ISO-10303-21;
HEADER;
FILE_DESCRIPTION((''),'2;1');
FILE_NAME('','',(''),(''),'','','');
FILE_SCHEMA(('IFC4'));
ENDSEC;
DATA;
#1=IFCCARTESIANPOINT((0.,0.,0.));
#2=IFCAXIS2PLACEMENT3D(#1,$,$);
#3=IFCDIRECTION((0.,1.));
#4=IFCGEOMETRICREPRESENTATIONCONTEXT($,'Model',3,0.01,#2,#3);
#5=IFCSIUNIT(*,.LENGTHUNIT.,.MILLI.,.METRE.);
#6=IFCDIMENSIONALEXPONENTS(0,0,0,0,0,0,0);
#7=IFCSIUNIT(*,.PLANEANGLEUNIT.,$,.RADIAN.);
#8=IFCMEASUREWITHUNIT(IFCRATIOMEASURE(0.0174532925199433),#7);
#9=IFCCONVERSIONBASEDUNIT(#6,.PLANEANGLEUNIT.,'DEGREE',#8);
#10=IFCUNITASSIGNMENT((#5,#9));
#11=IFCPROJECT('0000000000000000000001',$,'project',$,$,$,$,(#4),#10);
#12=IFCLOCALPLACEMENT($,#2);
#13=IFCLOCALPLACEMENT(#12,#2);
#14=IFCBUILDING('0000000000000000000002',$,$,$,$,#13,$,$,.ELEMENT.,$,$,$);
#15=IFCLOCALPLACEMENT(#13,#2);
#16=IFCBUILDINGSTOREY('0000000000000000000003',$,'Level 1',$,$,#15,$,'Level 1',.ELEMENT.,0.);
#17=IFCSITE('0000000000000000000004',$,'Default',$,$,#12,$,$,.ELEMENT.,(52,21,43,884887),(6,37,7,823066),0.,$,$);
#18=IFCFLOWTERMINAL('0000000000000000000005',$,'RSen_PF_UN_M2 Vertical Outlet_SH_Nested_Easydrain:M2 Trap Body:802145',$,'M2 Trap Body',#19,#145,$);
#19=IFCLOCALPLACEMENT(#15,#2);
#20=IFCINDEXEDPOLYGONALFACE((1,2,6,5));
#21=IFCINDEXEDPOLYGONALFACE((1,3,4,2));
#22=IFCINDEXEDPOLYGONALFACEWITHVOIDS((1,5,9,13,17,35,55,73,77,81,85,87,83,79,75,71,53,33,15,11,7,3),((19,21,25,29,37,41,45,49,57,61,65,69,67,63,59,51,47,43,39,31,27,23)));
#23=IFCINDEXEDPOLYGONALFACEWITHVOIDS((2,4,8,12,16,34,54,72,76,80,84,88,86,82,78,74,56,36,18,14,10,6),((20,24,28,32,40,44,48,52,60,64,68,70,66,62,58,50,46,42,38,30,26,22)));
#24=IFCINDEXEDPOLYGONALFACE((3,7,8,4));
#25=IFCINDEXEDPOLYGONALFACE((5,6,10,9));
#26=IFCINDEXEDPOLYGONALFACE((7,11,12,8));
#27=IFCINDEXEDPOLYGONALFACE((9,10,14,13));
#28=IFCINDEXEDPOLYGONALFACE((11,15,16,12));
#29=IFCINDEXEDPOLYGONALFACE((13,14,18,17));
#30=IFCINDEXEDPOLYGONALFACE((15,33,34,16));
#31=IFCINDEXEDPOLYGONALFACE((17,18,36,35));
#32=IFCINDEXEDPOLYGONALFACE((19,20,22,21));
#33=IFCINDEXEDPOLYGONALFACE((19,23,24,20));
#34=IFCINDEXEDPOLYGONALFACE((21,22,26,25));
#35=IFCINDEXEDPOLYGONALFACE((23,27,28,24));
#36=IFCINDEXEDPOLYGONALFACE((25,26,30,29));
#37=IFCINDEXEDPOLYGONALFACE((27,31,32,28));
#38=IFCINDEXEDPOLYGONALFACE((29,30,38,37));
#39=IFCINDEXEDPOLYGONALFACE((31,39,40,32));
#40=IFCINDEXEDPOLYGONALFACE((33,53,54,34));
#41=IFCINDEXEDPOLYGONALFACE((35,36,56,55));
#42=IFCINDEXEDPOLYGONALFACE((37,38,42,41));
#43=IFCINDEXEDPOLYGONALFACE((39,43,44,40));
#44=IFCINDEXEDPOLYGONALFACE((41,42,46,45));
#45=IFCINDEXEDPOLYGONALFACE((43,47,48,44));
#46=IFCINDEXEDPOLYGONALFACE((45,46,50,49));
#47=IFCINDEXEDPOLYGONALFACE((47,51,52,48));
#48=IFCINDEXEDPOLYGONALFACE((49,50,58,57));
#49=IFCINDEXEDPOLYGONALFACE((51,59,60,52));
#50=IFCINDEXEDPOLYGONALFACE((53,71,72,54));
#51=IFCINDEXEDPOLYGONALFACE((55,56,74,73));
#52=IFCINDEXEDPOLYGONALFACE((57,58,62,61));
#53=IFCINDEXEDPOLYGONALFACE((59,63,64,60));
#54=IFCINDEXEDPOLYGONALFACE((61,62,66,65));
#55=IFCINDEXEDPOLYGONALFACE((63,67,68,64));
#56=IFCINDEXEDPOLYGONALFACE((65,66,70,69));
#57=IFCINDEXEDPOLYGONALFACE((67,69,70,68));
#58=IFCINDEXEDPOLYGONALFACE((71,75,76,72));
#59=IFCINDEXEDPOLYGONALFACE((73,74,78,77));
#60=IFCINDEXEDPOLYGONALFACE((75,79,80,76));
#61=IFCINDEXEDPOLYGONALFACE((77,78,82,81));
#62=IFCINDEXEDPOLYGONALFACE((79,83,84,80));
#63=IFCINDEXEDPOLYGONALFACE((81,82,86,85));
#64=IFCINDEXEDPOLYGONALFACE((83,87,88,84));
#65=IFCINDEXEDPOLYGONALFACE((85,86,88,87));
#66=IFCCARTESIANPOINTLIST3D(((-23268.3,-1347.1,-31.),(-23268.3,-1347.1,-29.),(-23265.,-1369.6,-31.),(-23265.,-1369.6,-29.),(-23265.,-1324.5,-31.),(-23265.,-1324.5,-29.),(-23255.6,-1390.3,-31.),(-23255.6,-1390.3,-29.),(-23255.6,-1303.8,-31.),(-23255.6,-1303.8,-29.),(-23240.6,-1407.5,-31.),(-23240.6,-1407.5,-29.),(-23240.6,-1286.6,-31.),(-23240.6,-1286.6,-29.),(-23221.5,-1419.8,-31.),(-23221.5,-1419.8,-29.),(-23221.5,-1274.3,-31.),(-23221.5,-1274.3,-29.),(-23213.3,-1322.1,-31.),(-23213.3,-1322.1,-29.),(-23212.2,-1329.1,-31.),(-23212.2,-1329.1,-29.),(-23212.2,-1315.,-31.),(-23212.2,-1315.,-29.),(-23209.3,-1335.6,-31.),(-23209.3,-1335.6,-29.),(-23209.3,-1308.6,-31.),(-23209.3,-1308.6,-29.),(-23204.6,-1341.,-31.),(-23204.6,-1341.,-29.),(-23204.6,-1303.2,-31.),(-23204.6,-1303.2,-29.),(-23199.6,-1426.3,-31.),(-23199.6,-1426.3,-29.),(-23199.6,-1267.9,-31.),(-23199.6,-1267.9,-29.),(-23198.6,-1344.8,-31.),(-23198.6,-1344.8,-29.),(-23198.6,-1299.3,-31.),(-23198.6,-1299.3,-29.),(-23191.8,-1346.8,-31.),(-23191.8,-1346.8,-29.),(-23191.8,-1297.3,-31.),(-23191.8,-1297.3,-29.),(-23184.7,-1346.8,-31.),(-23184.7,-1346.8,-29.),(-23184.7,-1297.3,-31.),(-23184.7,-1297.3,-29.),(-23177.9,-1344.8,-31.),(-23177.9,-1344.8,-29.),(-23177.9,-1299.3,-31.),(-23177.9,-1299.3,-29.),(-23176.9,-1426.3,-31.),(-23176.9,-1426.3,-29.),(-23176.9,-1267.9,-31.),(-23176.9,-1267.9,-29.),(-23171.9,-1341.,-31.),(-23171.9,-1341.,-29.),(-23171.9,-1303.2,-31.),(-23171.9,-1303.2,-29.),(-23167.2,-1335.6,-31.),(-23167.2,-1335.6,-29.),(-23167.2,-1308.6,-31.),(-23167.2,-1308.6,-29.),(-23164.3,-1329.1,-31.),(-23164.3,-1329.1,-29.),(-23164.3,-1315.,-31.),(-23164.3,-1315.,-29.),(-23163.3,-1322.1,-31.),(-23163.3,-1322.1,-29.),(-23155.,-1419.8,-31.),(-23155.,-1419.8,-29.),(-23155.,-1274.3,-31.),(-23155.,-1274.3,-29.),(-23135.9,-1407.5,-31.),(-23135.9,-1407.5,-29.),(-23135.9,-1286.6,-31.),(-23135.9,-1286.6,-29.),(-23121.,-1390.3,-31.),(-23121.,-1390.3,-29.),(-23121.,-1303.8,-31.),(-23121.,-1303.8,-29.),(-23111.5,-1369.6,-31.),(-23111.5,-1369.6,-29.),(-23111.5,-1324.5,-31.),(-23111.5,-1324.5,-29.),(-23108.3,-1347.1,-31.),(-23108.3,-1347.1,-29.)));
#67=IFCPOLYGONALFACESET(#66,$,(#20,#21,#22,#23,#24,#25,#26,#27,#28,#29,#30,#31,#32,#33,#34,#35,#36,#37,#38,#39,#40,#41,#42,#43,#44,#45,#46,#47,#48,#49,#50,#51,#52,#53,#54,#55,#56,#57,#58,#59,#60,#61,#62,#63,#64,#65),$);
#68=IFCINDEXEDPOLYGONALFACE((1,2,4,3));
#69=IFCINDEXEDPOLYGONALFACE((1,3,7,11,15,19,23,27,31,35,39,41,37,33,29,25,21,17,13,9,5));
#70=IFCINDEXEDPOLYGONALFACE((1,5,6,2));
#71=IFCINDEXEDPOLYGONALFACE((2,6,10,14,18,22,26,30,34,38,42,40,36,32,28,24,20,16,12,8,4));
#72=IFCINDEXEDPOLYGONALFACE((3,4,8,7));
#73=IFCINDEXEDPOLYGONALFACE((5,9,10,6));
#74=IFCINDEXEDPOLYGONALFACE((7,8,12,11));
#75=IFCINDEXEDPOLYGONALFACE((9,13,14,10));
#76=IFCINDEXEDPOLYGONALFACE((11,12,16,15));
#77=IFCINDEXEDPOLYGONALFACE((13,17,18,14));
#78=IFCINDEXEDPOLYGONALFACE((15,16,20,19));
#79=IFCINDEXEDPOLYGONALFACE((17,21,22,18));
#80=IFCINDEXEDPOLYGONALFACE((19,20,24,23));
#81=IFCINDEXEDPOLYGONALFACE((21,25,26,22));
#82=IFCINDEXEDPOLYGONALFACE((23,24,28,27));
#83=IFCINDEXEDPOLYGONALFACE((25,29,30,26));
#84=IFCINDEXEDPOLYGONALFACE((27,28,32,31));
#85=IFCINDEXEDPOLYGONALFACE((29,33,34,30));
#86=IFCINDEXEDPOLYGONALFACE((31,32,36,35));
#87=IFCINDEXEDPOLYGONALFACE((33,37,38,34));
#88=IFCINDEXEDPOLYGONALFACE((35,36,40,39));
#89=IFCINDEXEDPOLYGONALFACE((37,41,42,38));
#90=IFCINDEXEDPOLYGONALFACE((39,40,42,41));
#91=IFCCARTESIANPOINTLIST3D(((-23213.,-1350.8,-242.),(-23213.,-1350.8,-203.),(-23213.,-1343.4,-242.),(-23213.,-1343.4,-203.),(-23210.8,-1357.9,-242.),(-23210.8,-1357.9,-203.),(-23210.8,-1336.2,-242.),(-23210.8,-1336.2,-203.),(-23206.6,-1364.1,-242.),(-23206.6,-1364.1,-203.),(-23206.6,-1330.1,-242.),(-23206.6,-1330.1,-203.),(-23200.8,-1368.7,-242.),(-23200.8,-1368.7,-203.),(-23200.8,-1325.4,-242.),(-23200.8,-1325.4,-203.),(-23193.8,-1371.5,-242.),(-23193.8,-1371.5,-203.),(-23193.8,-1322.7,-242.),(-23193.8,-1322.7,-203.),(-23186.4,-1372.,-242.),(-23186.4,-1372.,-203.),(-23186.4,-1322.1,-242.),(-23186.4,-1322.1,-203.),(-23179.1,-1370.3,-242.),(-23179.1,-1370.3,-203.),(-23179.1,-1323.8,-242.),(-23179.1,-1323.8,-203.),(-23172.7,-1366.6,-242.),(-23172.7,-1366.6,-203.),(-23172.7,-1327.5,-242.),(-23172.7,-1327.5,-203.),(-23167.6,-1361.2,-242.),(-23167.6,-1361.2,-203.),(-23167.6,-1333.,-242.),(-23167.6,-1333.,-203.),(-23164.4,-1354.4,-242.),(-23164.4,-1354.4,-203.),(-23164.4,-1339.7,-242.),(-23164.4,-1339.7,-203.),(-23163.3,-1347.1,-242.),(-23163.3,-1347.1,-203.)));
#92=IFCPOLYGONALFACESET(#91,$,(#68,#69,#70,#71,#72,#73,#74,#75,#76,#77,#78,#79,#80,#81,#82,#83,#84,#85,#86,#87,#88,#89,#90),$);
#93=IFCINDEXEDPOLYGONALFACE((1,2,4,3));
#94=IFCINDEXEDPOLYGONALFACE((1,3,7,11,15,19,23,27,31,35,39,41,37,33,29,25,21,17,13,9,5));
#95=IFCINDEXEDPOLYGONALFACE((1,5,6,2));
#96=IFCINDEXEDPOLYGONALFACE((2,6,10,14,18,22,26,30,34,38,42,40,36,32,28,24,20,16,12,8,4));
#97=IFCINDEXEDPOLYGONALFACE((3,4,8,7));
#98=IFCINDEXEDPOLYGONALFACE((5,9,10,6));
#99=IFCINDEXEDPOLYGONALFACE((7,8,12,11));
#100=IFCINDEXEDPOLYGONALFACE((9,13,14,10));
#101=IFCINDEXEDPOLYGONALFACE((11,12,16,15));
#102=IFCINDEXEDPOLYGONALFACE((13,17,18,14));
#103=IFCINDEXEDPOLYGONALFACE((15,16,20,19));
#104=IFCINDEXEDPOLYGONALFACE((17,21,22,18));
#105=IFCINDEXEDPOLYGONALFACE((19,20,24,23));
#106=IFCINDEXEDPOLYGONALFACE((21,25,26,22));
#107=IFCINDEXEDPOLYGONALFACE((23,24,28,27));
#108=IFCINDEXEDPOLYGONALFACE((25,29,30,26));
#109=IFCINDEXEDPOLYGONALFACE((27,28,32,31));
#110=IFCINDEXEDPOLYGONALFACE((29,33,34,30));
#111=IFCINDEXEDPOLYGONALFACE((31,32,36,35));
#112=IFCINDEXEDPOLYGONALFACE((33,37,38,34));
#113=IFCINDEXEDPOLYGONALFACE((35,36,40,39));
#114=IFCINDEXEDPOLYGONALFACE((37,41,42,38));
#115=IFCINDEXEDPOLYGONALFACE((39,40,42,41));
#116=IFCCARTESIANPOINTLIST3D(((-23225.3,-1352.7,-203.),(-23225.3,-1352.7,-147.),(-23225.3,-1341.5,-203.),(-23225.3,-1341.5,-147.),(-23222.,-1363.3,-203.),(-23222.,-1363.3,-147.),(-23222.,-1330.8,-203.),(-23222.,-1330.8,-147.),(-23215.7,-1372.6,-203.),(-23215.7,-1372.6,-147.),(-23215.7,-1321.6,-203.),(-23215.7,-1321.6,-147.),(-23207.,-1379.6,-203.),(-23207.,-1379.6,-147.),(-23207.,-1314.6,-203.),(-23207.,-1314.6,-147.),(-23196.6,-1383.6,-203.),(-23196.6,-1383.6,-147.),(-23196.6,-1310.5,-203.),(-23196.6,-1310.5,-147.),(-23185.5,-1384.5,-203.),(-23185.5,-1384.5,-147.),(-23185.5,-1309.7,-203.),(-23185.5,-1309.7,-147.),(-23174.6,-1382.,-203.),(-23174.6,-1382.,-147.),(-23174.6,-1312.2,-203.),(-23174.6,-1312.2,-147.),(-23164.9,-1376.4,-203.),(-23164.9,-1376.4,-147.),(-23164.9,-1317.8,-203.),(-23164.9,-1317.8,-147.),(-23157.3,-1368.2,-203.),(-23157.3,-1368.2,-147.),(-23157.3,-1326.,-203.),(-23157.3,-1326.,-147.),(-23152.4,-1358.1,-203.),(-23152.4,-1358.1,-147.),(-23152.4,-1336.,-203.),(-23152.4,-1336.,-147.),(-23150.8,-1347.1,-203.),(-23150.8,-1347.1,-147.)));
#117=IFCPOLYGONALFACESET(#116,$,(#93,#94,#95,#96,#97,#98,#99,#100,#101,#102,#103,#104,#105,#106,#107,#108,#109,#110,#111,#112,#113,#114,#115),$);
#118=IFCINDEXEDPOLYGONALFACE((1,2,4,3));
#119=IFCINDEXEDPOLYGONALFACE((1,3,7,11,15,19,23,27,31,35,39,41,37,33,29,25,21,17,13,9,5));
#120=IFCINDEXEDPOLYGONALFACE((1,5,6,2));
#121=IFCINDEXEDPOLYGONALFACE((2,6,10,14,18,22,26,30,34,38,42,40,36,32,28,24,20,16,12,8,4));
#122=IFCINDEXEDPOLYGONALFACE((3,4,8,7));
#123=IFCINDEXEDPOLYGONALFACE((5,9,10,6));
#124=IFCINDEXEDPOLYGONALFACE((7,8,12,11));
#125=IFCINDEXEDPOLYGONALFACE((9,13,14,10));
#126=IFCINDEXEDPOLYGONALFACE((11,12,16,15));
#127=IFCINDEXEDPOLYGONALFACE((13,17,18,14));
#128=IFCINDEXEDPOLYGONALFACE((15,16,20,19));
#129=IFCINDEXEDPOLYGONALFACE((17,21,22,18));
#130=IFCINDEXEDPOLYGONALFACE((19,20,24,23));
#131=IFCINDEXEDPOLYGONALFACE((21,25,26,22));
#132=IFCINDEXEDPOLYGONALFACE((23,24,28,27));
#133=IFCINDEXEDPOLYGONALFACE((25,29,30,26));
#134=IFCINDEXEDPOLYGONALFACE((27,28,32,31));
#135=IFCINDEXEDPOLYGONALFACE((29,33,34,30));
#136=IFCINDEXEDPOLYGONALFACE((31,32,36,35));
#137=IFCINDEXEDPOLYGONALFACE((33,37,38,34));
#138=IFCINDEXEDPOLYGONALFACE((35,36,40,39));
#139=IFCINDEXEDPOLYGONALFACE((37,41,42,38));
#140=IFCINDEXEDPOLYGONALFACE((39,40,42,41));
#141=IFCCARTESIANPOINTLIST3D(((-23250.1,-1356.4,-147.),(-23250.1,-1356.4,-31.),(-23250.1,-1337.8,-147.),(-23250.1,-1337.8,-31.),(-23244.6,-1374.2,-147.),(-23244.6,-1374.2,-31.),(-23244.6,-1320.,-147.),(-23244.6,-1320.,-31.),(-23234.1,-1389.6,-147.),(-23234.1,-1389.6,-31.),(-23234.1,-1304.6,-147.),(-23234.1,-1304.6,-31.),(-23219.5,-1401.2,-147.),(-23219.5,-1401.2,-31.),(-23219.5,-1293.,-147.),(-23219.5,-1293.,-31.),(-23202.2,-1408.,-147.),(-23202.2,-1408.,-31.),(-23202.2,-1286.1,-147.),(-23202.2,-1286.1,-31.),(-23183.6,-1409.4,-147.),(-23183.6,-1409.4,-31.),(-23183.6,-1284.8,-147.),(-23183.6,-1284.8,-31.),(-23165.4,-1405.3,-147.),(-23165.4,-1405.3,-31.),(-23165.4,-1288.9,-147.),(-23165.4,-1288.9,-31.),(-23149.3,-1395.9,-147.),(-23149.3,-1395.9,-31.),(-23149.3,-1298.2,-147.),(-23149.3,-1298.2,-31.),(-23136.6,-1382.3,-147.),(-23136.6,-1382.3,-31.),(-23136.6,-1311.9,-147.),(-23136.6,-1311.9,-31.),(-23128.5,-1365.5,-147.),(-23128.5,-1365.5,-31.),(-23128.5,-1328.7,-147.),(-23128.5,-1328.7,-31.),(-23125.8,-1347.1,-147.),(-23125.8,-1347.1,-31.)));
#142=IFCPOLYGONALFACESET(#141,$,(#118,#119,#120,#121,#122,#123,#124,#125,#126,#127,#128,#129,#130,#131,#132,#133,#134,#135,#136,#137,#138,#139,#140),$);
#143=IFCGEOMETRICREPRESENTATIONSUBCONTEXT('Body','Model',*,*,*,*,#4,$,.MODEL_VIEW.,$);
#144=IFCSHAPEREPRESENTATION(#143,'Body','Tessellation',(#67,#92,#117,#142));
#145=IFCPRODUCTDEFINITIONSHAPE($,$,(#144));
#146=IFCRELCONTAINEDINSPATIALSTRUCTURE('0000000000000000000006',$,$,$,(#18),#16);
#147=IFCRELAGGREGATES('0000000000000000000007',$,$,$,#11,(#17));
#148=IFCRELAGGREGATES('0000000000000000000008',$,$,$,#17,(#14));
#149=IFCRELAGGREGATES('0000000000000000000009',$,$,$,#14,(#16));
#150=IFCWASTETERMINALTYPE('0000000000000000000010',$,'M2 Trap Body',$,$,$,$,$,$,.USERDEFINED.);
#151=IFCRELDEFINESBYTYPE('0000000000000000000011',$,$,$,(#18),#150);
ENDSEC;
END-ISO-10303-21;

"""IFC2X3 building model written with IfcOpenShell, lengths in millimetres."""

from ifc_helpers import new_model, entity, si_unit, converted_unit, direction, frame, frame_2d, origin, origin_2d_with_axis, place, context, subcontext, project, spatial, circle_curve, parameter, trimmed, segment, composite_curve, circle, outline, extrude, source, transform, mapped, type_object, type_shapes, element, save


model = new_model("IFC2X3")

# Units and contexts
model_context = context("Model", 3, precision=0.01, world=origin(), true_north=direction((0.0, 1.0)))
body_context = subcontext(model_context, "Body", "Model", "MODEL_VIEW")
ifc_project = project(units=[si_unit("LENGTHUNIT", "METRE", prefix="MILLI"), converted_unit("PLANEANGLEUNIT", "DEGREE", entity("IfcRatioMeasure", 0.0174532925199433), si_unit("PLANEANGLEUNIT", "RADIAN"), dimensions=[0, 0, 0, 0, 0, 0, 0])], contexts=[model_context])

# Site, building, storey
site_placement = place(None, origin())
site = spatial("IfcSite", under=ifc_project, at=site_placement, Name="Default", CompositionType="ELEMENT", RefLatitude=(52, 21, 43, 884887), RefLongitude=(6, 37, 7, 823066), RefElevation=0.0)
building_placement = place(site_placement, origin())
building = spatial("IfcBuilding", under=site, at=building_placement, CompositionType="ELEMENT")
storey_placement = place(building_placement, origin())
storey = spatial("IfcBuildingStorey", under=building, at=storey_placement, Name="Level 1", LongName="Level 1", CompositionType="ELEMENT", Elevation=0.0)

# Flow terminal
waste_terminal_type_1 = type_object("IfcWasteTerminalType", Name="M2 Trap Body", PredefinedType="USERDEFINED")
shared_shape_1 = source(origin(), body_context, "Body", "SweptSolid", [
    extrude(outline(composite_curve([segment(trimmed(circle_curve(origin_2d_with_axis(), 80.0), [parameter(0.0)], [parameter(180.0)], True, "PARAMETER"), True, "CONTINUOUS"), segment(trimmed(circle_curve(origin_2d_with_axis(), 80.0), [parameter(180.0)], [parameter(360.0)], True, "PARAMETER"), True, "CONTINUOUS")], self_intersect=False), holes=[composite_curve([segment(trimmed(circle_curve(frame_2d((0.0, 25.0), x_axis=(1.0, 0.0)), 25.0), [parameter(180.0)], [parameter(360.0)], True, "PARAMETER"), False, "CONTINUOUS"), segment(trimmed(circle_curve(frame_2d((0.0, 25.0), x_axis=(1.0, 0.0)), 25.0), [parameter(0.0)], [parameter(180.0)], True, "PARAMETER"), False, "CONTINUOUS")], self_intersect=False)]), frame((0.0, -25.0, -2.0)), (0.0, 0.0, 1.0), 2.0),
    extrude(circle(Radius=25.0, at=frame_2d((0.0, 0.0), x_axis=(1.0, 0.0))), frame((0.0, -25.0, -213.0)), (0.0, 0.0, 1.0), 39.0),
    extrude(circle(Radius=37.5, at=frame_2d((0.0, 0.0), x_axis=(1.0, 0.0))), frame((0.0, -25.0, -174.0)), (0.0, 0.0, 1.0), 56.0),
    extrude(circle(Radius=62.5, at=frame_2d((0.0, 0.0), x_axis=(1.0, 0.0))), frame((0.0, -25.0, -118.0)), (0.0, 0.0, 1.0), 116.0),
])
type_shapes(waste_terminal_type_1, [shared_shape_1])
for number, where, name in (
    (1, (-23188.3, -1322.1, -29.0), "RSen_PF_UN_M2 Vertical Outlet_SH_Nested_Easydrain:M2 Trap Body:802145"),
):
    element("IfcFlowTerminal", number, at=place(storey_placement, frame(where)), inside=storey, type_object=waste_terminal_type_1, Name=name, ObjectType="M2 Trap Body", context=body_context, shape_type="MappedRepresentation", body=[
        mapped(shared_shape_1, transform((0.0, 0.0, 0.0), scale=1.0)),
    ])

save(model, "model.ifc")
